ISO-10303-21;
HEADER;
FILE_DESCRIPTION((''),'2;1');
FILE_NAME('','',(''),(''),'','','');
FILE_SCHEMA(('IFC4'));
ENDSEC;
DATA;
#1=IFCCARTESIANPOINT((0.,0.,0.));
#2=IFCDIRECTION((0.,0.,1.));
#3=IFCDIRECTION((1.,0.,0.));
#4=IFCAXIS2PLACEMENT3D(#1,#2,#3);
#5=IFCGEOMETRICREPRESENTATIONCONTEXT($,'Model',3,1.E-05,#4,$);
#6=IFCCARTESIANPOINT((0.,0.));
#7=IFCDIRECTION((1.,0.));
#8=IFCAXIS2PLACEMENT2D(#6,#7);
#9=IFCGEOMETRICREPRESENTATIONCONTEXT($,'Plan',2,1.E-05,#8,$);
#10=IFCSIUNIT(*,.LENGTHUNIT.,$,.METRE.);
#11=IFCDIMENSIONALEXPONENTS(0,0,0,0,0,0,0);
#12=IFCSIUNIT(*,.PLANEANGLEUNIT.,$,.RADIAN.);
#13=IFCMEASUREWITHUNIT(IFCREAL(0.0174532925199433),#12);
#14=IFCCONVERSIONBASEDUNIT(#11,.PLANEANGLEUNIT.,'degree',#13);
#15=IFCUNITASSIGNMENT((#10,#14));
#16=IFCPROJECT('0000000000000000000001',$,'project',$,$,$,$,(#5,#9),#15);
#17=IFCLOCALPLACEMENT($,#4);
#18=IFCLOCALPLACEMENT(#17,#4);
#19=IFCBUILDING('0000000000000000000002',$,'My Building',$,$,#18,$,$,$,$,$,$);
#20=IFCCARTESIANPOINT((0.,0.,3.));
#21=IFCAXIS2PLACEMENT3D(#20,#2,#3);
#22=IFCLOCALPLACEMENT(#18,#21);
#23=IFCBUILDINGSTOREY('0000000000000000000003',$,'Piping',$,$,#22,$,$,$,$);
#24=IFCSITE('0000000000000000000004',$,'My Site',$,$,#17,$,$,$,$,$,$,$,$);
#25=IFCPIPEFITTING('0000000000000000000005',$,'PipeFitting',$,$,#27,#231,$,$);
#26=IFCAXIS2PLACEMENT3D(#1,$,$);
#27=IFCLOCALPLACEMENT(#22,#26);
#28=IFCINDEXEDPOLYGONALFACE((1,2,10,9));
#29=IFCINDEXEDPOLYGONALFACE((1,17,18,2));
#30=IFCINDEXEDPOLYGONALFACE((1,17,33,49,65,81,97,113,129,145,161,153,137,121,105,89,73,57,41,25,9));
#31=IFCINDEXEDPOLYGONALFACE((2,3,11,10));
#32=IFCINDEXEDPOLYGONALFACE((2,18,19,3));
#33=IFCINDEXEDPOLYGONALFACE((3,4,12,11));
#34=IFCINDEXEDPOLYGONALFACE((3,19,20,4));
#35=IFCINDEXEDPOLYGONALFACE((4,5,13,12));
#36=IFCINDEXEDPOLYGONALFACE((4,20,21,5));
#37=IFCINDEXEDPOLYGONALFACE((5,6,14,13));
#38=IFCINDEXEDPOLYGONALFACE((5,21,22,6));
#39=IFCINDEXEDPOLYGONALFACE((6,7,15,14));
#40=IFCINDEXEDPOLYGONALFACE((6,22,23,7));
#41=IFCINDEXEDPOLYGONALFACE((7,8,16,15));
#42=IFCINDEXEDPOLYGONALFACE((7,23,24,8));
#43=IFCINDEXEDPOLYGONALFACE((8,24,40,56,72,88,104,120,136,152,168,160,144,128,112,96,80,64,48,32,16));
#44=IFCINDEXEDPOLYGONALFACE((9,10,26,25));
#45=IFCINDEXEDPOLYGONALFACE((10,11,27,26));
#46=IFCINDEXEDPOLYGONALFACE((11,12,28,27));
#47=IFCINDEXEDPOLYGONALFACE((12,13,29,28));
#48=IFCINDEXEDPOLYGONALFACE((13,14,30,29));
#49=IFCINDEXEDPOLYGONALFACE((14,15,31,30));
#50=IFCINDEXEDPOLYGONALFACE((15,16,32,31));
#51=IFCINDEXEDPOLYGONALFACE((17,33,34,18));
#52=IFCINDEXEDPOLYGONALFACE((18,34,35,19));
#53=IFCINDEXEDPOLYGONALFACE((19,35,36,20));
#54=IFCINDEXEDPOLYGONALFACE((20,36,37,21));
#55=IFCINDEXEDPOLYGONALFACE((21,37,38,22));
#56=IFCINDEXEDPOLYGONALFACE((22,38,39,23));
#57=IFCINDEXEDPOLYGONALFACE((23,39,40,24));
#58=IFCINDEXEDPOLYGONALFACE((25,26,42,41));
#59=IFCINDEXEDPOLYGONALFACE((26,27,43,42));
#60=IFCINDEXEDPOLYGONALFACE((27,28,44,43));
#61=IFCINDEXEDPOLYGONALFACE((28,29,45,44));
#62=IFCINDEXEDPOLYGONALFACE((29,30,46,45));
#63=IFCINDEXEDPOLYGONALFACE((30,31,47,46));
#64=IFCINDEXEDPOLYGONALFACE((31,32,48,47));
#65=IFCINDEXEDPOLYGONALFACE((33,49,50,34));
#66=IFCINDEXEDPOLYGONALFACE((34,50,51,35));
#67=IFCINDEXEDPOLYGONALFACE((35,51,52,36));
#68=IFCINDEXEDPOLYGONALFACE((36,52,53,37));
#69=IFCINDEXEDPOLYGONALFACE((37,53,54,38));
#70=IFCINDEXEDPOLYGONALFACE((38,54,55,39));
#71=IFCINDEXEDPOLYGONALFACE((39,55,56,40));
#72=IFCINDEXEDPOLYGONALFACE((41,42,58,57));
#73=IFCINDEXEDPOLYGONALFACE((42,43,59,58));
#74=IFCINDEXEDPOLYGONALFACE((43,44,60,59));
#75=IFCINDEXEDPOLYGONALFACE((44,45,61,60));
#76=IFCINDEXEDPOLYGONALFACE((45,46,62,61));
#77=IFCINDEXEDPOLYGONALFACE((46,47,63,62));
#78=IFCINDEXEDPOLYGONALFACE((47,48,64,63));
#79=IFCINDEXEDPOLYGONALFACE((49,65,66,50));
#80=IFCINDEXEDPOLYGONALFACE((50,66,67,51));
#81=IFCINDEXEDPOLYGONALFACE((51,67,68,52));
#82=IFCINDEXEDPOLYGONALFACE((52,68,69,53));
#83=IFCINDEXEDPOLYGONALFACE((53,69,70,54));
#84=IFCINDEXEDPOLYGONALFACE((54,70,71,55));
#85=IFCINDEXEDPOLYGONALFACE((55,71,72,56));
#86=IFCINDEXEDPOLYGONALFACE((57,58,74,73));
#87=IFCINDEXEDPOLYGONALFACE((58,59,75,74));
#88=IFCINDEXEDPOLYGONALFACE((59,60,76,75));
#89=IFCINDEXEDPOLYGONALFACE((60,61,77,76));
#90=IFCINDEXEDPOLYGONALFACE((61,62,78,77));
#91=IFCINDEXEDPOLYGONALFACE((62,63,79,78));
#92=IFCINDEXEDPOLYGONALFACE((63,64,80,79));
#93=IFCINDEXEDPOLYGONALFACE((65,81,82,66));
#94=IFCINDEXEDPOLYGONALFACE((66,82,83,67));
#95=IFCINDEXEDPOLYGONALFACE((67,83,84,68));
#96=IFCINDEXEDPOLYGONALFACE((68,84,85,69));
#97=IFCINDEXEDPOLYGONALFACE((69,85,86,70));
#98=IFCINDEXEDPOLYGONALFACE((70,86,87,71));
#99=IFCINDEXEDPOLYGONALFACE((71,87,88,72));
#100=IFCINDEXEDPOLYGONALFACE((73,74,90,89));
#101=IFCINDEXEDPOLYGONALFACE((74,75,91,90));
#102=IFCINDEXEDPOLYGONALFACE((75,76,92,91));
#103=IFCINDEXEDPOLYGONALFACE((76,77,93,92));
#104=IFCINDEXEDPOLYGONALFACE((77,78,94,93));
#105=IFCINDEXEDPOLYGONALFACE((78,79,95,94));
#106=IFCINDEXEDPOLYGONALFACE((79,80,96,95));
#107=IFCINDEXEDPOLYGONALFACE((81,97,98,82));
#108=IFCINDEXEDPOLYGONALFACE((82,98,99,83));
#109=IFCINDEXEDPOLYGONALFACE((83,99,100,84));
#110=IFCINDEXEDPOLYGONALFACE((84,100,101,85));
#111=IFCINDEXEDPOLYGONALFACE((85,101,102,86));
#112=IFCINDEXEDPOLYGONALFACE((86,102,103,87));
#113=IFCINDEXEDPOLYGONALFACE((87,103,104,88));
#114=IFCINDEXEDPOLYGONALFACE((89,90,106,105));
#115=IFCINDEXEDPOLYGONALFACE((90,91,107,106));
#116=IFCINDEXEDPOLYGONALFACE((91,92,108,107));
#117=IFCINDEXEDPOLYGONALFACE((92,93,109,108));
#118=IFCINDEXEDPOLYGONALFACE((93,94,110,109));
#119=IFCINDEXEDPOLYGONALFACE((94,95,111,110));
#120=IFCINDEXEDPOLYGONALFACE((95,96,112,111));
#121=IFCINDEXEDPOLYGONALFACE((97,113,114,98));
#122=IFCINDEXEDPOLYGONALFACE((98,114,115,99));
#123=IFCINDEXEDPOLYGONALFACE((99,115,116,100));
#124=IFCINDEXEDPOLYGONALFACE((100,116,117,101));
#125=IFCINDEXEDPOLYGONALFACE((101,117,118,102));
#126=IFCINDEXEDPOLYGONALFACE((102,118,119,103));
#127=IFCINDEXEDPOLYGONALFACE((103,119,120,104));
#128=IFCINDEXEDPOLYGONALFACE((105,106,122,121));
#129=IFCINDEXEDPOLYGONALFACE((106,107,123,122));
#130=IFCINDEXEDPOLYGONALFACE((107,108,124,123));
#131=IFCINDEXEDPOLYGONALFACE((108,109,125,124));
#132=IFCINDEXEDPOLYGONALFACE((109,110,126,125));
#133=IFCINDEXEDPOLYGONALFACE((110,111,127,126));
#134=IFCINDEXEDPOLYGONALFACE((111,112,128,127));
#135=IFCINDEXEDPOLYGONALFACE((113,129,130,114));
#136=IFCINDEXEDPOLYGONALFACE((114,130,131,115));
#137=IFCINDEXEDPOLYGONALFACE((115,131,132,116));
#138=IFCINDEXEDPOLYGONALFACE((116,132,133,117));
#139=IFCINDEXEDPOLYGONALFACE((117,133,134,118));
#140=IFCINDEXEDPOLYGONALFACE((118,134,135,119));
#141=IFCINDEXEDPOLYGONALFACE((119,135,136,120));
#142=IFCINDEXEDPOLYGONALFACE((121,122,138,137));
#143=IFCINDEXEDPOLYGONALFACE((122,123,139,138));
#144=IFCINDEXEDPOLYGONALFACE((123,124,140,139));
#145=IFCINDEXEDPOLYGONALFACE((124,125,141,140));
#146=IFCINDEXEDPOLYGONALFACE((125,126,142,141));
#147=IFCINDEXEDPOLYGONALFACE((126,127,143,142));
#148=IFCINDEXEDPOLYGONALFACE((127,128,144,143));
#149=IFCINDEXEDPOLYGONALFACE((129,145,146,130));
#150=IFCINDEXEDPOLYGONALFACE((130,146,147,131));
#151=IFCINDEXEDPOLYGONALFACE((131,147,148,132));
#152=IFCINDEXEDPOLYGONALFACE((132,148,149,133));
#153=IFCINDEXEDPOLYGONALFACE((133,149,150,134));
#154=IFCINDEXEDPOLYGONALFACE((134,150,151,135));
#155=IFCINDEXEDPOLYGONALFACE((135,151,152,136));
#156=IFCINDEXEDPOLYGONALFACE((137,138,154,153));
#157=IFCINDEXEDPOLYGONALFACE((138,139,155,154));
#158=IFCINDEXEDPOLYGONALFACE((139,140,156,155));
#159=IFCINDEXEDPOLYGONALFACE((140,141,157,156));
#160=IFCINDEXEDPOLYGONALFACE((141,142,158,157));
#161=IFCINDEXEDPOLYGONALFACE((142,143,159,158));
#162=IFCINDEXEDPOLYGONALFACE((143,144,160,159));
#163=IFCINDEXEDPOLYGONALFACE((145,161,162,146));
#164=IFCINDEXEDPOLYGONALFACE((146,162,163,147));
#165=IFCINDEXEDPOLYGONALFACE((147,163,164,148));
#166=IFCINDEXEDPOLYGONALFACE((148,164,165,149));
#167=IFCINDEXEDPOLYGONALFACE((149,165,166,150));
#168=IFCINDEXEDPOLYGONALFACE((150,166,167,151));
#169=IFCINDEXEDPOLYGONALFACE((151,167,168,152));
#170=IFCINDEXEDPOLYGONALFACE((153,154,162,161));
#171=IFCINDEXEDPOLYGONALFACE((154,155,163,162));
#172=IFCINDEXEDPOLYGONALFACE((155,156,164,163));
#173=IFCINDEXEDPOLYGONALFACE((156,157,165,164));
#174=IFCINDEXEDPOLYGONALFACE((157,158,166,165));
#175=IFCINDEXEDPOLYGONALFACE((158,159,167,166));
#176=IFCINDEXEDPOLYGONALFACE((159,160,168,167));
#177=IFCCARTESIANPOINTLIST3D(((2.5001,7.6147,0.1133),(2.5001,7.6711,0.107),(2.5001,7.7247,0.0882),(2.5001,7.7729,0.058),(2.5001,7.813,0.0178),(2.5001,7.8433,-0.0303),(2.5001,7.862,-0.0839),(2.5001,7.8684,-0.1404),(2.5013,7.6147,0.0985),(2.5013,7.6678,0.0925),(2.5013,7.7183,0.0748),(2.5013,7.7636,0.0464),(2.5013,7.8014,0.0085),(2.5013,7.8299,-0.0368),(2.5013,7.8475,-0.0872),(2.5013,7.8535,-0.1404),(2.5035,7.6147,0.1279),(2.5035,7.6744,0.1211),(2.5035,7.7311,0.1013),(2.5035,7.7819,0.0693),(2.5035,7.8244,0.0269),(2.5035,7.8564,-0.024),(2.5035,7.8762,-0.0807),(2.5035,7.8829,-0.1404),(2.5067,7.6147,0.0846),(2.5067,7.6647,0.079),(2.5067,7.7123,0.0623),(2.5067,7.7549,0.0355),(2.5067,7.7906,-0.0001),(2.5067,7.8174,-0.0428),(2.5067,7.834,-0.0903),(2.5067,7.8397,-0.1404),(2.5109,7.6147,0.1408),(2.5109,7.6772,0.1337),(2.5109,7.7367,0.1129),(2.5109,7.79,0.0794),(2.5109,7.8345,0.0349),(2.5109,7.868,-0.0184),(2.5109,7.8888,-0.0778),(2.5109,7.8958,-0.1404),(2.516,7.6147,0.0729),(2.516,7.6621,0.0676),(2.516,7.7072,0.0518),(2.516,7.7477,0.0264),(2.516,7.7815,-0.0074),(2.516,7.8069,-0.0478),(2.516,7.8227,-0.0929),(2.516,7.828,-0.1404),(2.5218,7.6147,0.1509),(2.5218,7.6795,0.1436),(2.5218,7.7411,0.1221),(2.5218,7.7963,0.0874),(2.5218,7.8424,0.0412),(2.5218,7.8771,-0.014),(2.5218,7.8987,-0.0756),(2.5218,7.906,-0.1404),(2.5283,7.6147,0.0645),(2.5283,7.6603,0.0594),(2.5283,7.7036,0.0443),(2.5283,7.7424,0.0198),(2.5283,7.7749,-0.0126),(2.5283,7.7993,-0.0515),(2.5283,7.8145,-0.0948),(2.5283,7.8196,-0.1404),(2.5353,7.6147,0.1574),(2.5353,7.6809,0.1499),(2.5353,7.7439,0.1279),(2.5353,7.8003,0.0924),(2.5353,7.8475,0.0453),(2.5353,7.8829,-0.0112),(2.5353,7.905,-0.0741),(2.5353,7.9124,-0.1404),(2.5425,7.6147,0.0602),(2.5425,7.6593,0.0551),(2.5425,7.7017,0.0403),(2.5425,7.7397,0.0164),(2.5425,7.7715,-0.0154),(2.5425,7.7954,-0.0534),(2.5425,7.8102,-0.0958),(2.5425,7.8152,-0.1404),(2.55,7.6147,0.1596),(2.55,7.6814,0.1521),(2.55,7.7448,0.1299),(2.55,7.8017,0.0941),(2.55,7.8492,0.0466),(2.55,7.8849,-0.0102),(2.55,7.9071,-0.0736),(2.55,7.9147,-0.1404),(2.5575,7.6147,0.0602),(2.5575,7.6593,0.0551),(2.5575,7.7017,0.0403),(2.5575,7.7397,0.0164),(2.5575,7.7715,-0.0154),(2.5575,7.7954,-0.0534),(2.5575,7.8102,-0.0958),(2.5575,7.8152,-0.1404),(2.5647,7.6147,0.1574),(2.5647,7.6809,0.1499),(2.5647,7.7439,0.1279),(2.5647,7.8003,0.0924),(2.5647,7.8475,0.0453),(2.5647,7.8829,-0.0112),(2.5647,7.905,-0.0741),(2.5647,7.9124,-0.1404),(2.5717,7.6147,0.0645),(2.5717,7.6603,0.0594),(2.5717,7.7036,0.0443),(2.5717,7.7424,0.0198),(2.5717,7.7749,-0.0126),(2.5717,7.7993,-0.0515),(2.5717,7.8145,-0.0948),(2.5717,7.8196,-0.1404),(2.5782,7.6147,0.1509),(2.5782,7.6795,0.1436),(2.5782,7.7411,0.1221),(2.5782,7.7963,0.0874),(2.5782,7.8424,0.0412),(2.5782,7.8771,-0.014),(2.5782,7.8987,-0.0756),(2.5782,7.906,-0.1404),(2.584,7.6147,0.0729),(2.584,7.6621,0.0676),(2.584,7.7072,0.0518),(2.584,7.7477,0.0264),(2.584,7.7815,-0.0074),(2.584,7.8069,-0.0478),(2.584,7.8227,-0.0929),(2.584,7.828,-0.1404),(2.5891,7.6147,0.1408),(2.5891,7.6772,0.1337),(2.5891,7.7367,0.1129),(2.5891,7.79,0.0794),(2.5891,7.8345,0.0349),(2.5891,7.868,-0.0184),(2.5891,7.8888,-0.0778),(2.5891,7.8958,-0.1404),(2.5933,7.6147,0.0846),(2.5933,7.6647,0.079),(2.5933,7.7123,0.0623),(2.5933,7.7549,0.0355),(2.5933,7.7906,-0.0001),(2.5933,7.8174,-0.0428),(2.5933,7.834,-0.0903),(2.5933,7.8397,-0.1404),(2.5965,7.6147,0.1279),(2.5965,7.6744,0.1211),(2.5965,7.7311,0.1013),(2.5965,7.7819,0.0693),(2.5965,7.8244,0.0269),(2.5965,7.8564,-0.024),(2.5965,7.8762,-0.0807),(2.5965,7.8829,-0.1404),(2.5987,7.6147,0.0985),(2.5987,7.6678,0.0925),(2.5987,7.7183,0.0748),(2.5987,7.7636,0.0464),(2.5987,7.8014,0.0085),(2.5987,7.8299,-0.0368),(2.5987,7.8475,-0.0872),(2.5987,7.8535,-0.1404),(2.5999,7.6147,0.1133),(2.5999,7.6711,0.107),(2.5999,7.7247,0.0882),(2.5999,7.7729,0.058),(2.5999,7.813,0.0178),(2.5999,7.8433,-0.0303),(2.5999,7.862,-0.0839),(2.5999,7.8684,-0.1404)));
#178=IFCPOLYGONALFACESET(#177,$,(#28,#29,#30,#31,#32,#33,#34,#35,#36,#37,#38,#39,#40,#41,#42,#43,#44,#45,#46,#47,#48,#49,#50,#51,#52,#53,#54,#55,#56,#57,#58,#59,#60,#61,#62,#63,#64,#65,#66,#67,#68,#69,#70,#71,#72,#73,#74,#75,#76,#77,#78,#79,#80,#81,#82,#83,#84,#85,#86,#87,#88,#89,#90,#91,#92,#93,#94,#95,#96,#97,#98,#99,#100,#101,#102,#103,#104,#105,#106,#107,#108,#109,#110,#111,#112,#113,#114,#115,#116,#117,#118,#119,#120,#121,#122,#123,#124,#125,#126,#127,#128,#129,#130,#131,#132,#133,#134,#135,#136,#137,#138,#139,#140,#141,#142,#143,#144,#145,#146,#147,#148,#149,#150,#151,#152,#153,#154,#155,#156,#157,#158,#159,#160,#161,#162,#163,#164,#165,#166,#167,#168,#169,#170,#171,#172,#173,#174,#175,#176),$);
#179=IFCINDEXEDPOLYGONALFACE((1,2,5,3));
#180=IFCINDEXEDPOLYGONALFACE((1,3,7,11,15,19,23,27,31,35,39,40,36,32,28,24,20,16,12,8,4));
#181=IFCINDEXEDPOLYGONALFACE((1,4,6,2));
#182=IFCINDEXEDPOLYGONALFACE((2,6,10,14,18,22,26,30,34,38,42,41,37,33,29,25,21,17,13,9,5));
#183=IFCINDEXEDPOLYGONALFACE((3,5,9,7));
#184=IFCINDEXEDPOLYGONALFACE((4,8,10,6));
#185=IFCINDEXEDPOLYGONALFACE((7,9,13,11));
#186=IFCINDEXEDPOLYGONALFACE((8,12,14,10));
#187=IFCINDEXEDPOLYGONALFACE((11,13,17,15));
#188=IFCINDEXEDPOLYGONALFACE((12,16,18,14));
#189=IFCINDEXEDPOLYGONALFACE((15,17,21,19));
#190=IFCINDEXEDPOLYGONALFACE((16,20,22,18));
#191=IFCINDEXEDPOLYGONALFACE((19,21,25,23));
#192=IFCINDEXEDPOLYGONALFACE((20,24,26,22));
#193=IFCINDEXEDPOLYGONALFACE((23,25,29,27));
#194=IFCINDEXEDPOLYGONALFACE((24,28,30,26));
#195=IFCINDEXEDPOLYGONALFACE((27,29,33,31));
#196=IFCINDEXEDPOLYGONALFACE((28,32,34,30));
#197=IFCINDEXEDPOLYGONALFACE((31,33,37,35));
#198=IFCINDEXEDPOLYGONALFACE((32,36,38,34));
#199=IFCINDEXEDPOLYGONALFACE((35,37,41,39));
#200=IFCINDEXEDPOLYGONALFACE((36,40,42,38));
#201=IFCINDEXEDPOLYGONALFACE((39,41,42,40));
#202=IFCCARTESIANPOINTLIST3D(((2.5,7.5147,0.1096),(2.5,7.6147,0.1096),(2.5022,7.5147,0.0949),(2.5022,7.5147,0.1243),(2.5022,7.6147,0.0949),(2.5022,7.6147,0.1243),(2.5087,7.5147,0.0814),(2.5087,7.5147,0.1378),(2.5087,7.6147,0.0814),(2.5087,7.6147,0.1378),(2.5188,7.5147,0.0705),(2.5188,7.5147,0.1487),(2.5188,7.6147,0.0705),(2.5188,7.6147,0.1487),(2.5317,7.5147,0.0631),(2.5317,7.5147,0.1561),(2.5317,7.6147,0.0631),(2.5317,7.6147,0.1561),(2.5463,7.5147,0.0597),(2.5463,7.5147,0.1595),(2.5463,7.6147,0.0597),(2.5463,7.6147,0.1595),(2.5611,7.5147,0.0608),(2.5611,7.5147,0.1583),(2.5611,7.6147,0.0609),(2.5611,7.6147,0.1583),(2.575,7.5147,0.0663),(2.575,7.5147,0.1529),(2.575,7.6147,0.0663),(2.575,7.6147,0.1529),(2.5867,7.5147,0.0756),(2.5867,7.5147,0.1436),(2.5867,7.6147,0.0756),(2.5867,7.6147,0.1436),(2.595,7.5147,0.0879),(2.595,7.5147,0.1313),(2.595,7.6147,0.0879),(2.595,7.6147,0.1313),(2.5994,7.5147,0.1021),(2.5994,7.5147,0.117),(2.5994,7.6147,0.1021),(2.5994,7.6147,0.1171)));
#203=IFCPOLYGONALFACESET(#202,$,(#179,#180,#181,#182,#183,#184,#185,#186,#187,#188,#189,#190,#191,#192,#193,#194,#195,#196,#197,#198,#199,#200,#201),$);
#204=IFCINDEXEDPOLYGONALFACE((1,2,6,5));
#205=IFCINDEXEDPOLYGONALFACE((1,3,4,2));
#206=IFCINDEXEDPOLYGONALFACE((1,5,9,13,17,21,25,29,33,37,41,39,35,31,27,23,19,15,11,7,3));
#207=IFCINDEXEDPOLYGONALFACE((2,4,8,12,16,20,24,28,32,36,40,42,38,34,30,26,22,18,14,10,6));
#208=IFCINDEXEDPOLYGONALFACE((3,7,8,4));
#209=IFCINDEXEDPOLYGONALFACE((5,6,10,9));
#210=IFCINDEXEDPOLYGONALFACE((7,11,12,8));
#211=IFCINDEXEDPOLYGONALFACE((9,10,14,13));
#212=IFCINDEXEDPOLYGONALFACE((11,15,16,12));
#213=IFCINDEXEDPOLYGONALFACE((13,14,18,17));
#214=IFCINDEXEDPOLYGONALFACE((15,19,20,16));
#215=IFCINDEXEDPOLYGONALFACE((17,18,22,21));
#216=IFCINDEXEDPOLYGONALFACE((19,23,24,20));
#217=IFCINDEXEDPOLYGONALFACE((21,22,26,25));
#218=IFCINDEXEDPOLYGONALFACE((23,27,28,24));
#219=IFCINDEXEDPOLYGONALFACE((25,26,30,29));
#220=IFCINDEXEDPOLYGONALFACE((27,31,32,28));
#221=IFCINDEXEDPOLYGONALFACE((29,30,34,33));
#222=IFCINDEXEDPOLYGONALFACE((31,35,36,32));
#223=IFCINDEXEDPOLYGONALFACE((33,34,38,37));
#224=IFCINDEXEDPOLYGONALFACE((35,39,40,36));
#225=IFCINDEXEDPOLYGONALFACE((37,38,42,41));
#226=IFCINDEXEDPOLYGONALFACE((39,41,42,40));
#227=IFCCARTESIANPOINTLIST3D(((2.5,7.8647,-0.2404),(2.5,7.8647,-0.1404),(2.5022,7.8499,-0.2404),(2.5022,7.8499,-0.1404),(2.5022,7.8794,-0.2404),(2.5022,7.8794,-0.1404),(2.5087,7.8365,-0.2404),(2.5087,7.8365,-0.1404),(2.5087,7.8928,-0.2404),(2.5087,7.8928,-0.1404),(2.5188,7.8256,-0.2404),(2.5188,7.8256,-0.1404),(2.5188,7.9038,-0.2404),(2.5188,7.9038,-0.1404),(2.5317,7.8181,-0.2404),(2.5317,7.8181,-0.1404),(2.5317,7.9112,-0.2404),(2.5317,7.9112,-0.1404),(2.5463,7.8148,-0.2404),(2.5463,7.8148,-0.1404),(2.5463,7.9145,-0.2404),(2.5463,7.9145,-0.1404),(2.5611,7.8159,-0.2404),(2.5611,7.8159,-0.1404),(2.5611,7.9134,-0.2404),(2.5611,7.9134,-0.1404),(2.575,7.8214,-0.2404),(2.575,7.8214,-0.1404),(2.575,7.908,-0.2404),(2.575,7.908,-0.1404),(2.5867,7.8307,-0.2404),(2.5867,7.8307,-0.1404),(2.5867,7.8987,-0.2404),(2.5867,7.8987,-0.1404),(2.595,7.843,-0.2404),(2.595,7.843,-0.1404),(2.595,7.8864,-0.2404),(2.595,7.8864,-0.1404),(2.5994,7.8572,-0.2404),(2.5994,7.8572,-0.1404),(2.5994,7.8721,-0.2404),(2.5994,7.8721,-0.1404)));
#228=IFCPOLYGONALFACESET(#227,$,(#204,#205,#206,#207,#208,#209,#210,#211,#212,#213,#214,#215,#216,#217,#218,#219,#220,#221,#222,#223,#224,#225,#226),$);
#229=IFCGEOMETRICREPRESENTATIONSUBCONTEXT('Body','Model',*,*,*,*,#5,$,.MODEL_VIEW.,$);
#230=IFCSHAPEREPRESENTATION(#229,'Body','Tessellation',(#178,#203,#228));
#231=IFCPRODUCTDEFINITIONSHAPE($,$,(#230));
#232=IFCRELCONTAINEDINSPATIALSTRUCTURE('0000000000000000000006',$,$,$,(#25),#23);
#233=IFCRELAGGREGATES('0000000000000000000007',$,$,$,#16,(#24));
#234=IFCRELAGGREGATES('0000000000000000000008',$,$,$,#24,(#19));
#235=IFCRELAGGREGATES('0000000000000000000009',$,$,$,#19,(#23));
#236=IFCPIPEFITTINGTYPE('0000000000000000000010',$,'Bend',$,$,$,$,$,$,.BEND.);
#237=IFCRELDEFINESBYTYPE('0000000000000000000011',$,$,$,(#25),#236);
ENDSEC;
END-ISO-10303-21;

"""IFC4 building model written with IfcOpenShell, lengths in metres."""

from ifc_helpers import new_model, entity, si_unit, converted_unit, frame, origin_with_axes, origin_2d_with_axis, place, context, subcontext, project, spatial, circle, extrude, source, transform, mapped, type_object, type_shapes, element, save


model = new_model("IFC4")

# Units and contexts
model_context = context("Model", 3, precision=1e-05, world=origin_with_axes())
plan_context = context("Plan", 2, precision=1e-05, world=origin_2d_with_axis())
body_context = subcontext(model_context, "Body", "Model", "MODEL_VIEW")
ifc_project = project(units=[si_unit("LENGTHUNIT", "METRE"), converted_unit("PLANEANGLEUNIT", "degree", entity("IfcReal", 0.0174532925199433), si_unit("PLANEANGLEUNIT", "RADIAN"), dimensions=[0, 0, 0, 0, 0, 0, 0])], contexts=[model_context, plan_context])

# Site, building, storey
site_placement = place(None, origin_with_axes())
site = spatial("IfcSite", under=ifc_project, at=site_placement, Name="My Site")
building_placement = place(site_placement, origin_with_axes())
building = spatial("IfcBuilding", under=site, at=building_placement, Name="My Building")
storey_placement = place(building_placement, frame((0.0, 0.0, 3.0), z_axis=(0.0, 0.0, 1.0), x_axis=(1.0, 0.0, 0.0)))
storey = spatial("IfcBuildingStorey", under=building, at=storey_placement, Name="Piping")

# Pipe fitting
pipe_fitting_type_1 = type_object("IfcPipeFittingType", Name="Bend", PredefinedType="BEND")
shared_shape_1 = source(origin_with_axes(), body_context, "Body", "SolidModel", [
    entity("IfcSweptDiskSolid", entity("IfcIndexedPolyCurve", entity("IfcCartesianPointList3D", [[0.0, 0.0, 0.1], [0.0, -0.0732, 0.2768], [0.0, -0.25, 0.35]]), [entity("IfcArcIndex", [1, 2, 3])]), 0.05),
    extrude(circle(Radius=0.05), origin_with_axes(), (0.0, 0.0, 1.0), 0.1),
    extrude(circle(Radius=0.05), frame((0.0, -0.25, 0.35), z_axis=(0.0, -1.0, -0.000021), x_axis=(1.0, 0.0, 0.0)), (0.0, 0.0, 1.0), 0.1),
])
type_shapes(pipe_fitting_type_1, [shared_shape_1])
for number, where, z_axis, x_axis, name in (
    (1, (2.55, 7.5147, 0.1096), (-0.000001, 1.0, 0.000021), (-1.0, -0.000001, 0.0), "PipeFitting"),
):
    element("IfcPipeFitting", number, at=place(storey_placement, frame(where, z_axis=z_axis, x_axis=x_axis)), inside=storey, type_object=pipe_fitting_type_1, Name=name, context=body_context, shape_type="MappedRepresentation", body=[
        mapped(shared_shape_1, transform((0.0, 0.0, 0.0), x_axis=(1.0, 0.0, 0.0), y_axis=(0.0, 1.0, 0.0), z_axis=(0.0, 0.0, 1.0), scale=1.0)),
    ])

save(model, "model.ifc")
